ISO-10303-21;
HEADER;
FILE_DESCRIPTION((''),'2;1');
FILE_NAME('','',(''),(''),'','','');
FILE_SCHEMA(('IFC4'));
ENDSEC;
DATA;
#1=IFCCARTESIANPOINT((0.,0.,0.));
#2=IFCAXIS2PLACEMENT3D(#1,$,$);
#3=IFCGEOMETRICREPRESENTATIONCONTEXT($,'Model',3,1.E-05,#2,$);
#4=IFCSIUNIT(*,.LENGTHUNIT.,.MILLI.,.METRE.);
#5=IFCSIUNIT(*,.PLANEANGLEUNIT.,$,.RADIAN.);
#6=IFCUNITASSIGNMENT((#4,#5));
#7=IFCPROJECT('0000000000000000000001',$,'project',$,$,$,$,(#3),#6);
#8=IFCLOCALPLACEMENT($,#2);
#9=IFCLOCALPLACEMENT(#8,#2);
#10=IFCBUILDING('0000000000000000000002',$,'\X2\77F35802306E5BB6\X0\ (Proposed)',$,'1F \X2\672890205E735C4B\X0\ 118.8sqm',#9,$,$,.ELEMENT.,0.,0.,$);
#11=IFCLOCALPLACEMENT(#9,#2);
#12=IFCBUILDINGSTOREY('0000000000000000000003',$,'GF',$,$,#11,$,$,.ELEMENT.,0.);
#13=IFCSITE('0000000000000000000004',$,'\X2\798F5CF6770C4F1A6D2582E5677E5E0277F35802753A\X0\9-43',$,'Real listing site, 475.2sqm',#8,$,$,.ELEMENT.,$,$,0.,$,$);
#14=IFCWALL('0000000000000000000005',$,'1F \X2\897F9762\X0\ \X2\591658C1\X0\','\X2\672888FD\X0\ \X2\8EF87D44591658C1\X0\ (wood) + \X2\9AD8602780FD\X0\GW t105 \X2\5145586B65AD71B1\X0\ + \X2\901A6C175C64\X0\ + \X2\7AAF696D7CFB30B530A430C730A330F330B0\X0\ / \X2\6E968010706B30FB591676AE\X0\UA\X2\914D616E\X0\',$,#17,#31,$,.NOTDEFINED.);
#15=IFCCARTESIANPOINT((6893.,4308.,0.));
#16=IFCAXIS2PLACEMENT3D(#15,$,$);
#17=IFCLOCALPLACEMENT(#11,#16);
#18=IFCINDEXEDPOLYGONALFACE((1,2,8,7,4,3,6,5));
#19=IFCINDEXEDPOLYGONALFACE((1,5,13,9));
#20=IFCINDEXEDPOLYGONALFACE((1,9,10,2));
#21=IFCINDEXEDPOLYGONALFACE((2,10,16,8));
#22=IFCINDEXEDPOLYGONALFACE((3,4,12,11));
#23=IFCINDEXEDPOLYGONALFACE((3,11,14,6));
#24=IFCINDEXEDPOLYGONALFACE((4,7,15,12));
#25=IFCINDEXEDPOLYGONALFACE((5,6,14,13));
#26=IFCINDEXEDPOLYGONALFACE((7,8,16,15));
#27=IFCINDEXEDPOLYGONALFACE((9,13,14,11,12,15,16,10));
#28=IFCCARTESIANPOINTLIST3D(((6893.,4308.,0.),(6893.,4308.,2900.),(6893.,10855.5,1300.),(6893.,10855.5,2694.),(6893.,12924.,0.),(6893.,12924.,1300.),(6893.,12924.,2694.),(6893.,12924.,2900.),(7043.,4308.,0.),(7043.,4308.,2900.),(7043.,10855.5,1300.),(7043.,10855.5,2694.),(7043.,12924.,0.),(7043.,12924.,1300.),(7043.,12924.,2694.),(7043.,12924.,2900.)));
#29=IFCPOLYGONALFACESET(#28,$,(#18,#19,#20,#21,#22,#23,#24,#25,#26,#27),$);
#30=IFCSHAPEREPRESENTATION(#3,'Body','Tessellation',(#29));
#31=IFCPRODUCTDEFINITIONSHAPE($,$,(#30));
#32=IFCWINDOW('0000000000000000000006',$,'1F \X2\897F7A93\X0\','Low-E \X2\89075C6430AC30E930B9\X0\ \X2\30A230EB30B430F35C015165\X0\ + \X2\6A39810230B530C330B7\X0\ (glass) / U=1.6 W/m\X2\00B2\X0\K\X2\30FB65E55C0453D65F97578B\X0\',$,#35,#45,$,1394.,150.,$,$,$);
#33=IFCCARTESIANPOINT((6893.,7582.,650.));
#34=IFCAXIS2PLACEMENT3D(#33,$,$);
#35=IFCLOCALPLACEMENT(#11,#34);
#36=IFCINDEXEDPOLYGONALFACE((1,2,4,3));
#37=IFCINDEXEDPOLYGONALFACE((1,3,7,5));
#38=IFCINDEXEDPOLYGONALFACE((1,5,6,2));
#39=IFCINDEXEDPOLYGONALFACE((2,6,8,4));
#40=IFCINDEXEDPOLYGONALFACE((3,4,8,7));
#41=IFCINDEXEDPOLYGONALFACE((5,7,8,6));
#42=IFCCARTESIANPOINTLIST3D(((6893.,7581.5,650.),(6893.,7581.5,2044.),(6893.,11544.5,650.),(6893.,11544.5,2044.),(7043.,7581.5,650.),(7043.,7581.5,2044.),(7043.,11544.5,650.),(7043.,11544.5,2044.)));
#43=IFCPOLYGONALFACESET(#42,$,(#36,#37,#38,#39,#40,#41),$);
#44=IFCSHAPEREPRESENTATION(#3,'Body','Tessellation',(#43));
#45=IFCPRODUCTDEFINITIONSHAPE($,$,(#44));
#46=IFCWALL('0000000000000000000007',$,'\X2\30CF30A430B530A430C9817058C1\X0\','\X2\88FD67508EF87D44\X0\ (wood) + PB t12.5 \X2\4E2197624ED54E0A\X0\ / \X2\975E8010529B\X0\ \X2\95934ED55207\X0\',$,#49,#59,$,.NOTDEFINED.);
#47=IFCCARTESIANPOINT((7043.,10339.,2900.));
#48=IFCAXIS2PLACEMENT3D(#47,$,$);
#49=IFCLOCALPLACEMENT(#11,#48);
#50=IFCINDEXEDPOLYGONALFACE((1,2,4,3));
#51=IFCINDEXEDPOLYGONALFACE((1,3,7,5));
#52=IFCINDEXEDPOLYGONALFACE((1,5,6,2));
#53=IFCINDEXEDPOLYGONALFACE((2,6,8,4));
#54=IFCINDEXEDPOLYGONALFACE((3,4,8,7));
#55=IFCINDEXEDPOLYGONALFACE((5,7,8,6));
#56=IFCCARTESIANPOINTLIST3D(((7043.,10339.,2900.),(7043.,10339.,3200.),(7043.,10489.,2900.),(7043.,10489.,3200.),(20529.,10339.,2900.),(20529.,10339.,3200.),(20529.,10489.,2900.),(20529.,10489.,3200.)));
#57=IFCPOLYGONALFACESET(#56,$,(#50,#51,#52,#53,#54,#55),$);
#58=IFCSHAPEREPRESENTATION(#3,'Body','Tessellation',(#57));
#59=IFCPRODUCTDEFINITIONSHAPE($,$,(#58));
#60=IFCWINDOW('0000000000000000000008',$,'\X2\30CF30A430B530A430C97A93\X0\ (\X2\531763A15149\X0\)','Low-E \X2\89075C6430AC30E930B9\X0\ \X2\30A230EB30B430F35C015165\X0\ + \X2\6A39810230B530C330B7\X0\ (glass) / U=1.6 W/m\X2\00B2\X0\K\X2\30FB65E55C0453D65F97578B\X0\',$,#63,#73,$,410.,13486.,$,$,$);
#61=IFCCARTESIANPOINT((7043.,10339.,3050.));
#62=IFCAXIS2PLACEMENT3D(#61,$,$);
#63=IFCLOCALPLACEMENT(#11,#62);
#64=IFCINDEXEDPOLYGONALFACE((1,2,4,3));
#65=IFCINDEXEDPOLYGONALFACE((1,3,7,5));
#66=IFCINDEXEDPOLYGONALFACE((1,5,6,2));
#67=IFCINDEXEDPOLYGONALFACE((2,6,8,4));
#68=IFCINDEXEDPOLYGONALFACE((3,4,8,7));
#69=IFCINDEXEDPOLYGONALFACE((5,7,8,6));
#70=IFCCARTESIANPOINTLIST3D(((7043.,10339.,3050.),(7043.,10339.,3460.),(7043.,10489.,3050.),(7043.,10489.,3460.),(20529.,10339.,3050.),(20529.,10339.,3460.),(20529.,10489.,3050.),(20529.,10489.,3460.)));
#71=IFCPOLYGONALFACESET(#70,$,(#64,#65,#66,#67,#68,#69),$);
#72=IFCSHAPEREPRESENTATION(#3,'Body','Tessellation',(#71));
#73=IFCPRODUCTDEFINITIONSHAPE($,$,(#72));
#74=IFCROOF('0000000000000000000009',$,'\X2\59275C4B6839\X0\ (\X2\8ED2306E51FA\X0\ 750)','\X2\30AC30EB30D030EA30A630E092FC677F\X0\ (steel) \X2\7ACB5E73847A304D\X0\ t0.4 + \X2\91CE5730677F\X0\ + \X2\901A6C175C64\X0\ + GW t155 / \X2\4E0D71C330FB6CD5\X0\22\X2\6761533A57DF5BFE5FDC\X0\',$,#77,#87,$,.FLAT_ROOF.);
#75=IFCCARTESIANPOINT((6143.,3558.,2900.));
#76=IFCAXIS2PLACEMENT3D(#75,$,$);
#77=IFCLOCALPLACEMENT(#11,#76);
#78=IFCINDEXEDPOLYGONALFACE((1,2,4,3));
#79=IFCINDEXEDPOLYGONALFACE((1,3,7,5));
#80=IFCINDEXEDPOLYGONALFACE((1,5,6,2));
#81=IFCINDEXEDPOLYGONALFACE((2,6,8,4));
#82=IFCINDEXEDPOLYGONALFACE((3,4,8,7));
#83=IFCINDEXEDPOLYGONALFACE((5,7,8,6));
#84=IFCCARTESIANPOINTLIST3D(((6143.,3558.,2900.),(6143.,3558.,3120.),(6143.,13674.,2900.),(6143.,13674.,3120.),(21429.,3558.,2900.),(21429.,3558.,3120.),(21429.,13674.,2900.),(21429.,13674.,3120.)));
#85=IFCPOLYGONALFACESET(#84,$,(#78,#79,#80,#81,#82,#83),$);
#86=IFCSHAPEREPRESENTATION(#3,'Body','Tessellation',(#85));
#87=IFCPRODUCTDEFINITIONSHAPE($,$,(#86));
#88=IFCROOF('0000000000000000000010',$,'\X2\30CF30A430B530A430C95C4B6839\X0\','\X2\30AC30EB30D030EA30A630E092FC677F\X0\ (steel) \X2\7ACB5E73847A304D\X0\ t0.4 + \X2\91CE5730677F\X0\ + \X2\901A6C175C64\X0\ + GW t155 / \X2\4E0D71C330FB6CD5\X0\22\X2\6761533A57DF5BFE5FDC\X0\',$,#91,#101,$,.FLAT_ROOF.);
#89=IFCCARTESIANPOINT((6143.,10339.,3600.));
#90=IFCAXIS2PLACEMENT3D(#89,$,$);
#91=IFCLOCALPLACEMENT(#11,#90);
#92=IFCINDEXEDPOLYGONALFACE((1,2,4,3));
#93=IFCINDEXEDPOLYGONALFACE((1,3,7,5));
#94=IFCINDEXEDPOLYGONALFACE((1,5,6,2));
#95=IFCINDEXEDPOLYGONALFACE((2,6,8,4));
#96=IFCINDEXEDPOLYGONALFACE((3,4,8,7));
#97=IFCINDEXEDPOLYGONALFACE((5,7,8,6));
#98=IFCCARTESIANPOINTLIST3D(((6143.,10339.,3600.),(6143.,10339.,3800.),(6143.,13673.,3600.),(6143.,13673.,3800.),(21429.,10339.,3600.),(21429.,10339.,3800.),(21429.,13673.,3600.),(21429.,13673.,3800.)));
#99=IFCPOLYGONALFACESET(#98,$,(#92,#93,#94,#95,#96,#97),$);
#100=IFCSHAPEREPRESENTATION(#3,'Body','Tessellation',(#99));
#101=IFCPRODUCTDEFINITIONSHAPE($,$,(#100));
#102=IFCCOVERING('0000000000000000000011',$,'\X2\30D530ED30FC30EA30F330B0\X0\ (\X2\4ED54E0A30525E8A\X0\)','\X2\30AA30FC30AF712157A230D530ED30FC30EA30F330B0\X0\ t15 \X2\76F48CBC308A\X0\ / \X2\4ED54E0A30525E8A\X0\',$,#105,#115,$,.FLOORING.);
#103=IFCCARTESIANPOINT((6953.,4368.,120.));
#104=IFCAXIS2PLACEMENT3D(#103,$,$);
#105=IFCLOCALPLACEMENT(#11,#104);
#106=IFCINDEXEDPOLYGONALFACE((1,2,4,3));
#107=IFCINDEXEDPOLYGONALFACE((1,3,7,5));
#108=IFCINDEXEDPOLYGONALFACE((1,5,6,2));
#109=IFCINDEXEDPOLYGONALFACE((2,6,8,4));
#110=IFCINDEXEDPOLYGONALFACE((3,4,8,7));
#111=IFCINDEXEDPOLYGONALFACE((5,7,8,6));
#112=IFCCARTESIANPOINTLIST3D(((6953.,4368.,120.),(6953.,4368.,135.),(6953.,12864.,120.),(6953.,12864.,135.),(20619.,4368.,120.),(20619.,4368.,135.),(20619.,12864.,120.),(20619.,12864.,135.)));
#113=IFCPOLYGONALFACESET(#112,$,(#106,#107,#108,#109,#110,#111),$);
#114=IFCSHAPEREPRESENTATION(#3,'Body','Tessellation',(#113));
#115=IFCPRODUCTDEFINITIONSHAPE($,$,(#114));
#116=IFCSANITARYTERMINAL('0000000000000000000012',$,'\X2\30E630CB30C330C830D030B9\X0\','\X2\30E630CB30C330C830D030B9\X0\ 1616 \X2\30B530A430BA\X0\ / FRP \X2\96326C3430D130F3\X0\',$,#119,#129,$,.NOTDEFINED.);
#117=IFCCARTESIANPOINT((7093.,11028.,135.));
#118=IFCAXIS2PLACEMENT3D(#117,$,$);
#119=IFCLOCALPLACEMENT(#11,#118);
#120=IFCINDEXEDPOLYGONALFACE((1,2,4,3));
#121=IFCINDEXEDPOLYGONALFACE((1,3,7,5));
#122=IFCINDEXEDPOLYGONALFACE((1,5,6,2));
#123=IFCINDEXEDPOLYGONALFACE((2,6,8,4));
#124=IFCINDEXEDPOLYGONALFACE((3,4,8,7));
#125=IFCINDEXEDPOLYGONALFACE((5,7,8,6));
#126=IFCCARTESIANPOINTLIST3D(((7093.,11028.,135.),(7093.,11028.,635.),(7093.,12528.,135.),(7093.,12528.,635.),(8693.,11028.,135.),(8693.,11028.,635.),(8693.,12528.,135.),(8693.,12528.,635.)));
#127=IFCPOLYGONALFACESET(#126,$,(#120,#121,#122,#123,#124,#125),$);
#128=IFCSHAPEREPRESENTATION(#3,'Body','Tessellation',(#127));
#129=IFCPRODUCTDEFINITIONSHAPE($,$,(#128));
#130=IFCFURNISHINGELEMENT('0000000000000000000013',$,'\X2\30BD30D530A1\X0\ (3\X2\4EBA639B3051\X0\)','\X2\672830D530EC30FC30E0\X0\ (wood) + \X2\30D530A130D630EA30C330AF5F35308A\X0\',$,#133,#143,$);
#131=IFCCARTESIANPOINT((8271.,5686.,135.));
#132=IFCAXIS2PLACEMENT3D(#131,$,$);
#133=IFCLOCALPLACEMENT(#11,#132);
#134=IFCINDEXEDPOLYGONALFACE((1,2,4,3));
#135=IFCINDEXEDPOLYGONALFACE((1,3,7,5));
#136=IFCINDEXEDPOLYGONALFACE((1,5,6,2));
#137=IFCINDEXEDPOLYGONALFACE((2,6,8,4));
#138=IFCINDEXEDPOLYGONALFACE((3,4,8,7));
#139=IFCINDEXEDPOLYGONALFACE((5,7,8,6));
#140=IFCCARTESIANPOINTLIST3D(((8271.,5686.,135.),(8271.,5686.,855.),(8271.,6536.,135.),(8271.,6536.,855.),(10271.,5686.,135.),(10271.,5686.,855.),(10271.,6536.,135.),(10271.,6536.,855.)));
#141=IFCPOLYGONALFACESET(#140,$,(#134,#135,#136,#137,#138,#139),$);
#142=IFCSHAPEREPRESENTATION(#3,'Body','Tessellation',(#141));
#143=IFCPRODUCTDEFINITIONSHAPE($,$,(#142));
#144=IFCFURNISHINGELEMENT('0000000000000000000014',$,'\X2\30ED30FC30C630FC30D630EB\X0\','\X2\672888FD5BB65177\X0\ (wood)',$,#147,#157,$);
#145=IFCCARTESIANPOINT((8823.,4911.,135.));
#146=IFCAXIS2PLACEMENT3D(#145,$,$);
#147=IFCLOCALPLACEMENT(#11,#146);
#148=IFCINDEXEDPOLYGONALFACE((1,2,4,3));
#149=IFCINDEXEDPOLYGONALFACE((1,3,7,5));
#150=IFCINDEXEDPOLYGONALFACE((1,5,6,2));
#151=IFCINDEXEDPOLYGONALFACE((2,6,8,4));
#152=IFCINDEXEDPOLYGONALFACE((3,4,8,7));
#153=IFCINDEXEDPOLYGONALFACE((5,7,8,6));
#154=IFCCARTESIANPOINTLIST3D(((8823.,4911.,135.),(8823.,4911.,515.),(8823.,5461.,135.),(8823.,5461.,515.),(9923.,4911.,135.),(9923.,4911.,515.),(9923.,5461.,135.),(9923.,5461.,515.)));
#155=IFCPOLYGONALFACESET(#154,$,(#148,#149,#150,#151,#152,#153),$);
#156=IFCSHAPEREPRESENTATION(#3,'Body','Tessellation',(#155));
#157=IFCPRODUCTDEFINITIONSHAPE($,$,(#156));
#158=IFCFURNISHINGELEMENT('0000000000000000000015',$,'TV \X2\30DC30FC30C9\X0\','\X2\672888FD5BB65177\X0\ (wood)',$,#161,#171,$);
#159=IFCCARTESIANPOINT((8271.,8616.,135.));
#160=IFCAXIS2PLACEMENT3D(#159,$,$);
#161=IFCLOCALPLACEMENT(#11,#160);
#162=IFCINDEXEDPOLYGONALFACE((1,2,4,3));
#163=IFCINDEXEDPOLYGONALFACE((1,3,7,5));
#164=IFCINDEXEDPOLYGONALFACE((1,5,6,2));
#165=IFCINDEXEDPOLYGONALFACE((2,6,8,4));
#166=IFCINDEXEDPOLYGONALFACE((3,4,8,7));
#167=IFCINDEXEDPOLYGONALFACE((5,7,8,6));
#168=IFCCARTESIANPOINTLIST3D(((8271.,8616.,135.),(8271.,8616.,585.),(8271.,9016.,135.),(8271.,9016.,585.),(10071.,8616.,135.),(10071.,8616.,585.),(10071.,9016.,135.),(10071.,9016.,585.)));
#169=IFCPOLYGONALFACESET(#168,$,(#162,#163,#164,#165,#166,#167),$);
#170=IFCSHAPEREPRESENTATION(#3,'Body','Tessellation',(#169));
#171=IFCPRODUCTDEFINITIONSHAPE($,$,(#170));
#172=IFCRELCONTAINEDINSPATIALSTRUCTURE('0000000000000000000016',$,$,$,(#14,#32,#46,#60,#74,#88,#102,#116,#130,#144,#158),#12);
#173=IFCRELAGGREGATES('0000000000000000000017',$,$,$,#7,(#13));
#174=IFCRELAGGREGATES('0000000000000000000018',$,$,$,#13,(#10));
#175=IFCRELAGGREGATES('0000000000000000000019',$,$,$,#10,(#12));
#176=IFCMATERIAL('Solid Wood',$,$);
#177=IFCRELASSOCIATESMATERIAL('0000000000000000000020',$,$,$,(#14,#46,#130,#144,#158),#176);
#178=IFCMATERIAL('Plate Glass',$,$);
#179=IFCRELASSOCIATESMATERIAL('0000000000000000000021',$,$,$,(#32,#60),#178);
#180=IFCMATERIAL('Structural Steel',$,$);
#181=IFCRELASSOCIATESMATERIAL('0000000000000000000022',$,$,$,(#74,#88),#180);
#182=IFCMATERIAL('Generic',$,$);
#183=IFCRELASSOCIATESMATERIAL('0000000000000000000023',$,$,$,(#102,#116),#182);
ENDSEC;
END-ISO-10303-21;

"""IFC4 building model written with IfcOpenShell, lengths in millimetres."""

from ifc_helpers import new_model, si_unit, frame, frame_2d, origin, place, context, project, spatial, rectangle, extrude, material, element, fill, save


model = new_model("IFC4")

# Units and contexts
model_context = context("Model", 3, precision=1e-05, world=origin())
ifc_project = project(units=[si_unit("LENGTHUNIT", "METRE", prefix="MILLI"), si_unit("PLANEANGLEUNIT", "RADIAN")], contexts=[model_context])

# Site, building, storey
site_placement = place(None, origin())
site = spatial("IfcSite", under=ifc_project, at=site_placement, Name="福島県会津若松市石堂町9-43", ObjectType="Real listing site, 475.2sqm", CompositionType="ELEMENT", RefElevation=0.0)
building_placement = place(site_placement, origin())
building = spatial("IfcBuilding", under=site, at=building_placement, Name="石堂の家 (Proposed)", ObjectType="1F 木造平屋 118.8sqm", CompositionType="ELEMENT", ElevationOfRefHeight=0.0, ElevationOfTerrain=0.0)
storey_placement = place(building_placement, origin())
storey = spatial("IfcBuildingStorey", under=building, at=storey_placement, Name="GF", CompositionType="ELEMENT", Elevation=0.0)

# Shared definitions
ifc_material_1 = material(Name="Solid Wood")

# Shared definitions
ifc_material_2 = material(Name="Plate Glass")

# Wall, opening, window
wall_1_placement = place(storey_placement, frame((6893.0, 4308.0, 0.0)))
wall_1 = element("IfcWall", 1, at=wall_1_placement, inside=storey, material=ifc_material_1, Name="1F 西面 外壁", Description="木製 軸組外壁 (wood) + 高性能GW t105 充填断熱 + 通気層 + 窯業系サイディング / 準耐火・外皮UA配慮", PredefinedType="NOTDEFINED", context=model_context, shape_type="SweptSolid", body=[
    extrude(rectangle(XDim=150.0, YDim=8616.0, at=frame_2d((75.0, 4308.0))), frame((6893.0, 4308.0, 0.0)), (0.0, 0.0, 1.0), 2900.0),
])
opening_1_placement = place(storey_placement, frame((6893.0, 7582.0, 650.0)))
opening_1 = element("IfcOpeningElement", 2, at=opening_1_placement, cuts=wall_1, PredefinedType="NOTDEFINED", context=model_context, shape_type="SweptSolid", body=[
    extrude(rectangle(XDim=150.0, YDim=3963.0, at=frame_2d((75.0, 1981.0))), frame((6893.0, 7582.0, 650.0)), (0.0, 0.0, 1.0), 1394.0),
])
window_1_placement = place(storey_placement, frame((6893.0, 7582.0, 650.0)))
window_1 = element("IfcWindow", 3, at=window_1_placement, inside=storey, material=ifc_material_2, Name="1F 西窓", Description="Low-E 複層ガラス アルゴン封入 + 樹脂サッシ (glass) / U=1.6 W/m²K・日射取得型", OverallHeight=1394.0, OverallWidth=150.0, context=model_context, shape_type="SweptSolid", body=[
    extrude(rectangle(XDim=150.0, YDim=3963.0, at=frame_2d((75.0, 1981.0))), frame((6893.0, 7582.0, 650.0)), (0.0, 0.0, 1.0), 1394.0),
])
fill(opening_1, window_1)

# Wall, opening, window
wall_2_placement = place(storey_placement, frame((7043.0, 10339.0, 2900.0)))
wall_2 = element("IfcWall", 4, at=wall_2_placement, inside=storey, material=ifc_material_1, Name="ハイサイド腰壁", Description="製材軸組 (wood) + PB t12.5 両面仕上 / 非耐力 間仕切", PredefinedType="NOTDEFINED", context=model_context, shape_type="SweptSolid", body=[
    extrude(rectangle(XDim=13486.0, YDim=150.0, at=frame_2d((6743.0, 75.0))), frame((7043.0, 10339.0, 2900.0)), (0.0, 0.0, 1.0), 700.0),
])
opening_2_placement = place(storey_placement, frame((7043.0, 10339.0, 3050.0)))
opening_2 = element("IfcOpeningElement", 5, at=opening_2_placement, cuts=wall_2, PredefinedType="NOTDEFINED", context=model_context, shape_type="SweptSolid", body=[
    extrude(rectangle(XDim=13486.0, YDim=150.0, at=frame_2d((6743.0, 75.0))), frame((7043.0, 10339.0, 3050.0)), (0.0, 0.0, 1.0), 410.0),
])
window_2_placement = place(storey_placement, frame((7043.0, 10339.0, 3050.0)))
window_2 = element("IfcWindow", 6, at=window_2_placement, inside=storey, material=ifc_material_2, Name="ハイサイド窓 (北採光)", Description="Low-E 複層ガラス アルゴン封入 + 樹脂サッシ (glass) / U=1.6 W/m²K・日射取得型", OverallHeight=410.0, OverallWidth=13486.0, context=model_context, shape_type="SweptSolid", body=[
    extrude(rectangle(XDim=13486.0, YDim=150.0, at=frame_2d((6743.0, 75.0))), frame((7043.0, 10339.0, 3050.0)), (0.0, 0.0, 1.0), 410.0),
])
fill(opening_2, window_2)

# Roofs
ifc_material_3 = material(Name="Structural Steel")
roof_1_placement = place(storey_placement, frame((6143.0, 3558.0, 2900.0)))
element("IfcRoof", 7, at=roof_1_placement, inside=storey, material=ifc_material_3, Name="大屋根 (軒の出 750)", Description="ガルバリウム鋼板 (steel) 立平葺き t0.4 + 野地板 + 通気層 + GW t155 / 不燃・法22条区域対応", PredefinedType="FLAT_ROOF", context=model_context, shape_type="SweptSolid", body=[
    extrude(rectangle(XDim=15286.0, YDim=10116.0, at=frame_2d((7643.0, 5058.0))), frame((6143.0, 3558.0, 2900.0)), (0.0, 0.0, 1.0), 220.0),
])
roof_2_placement = place(storey_placement, frame((6143.0, 10339.0, 3600.0)))
element("IfcRoof", 8, at=roof_2_placement, inside=storey, material=ifc_material_3, Name="ハイサイド屋根", Description="ガルバリウム鋼板 (steel) 立平葺き t0.4 + 野地板 + 通気層 + GW t155 / 不燃・法22条区域対応", PredefinedType="FLAT_ROOF", context=model_context, shape_type="SweptSolid", body=[
    extrude(rectangle(XDim=15286.0, YDim=3334.0, at=frame_2d((7643.0, 1667.0))), frame((6143.0, 10339.0, 3600.0)), (0.0, 0.0, 1.0), 200.0),
])

# Covering
ifc_material_4 = material(Name="Generic")
covering_placement = place(storey_placement, frame((6953.0, 4368.0, 120.0)))
element("IfcCovering", 9, at=covering_placement, inside=storey, material=ifc_material_4, Name="フローリング (仕上げ床)", Description="オーク無垢フローリング t15 直貼り / 仕上げ床", PredefinedType="FLOORING", context=model_context, shape_type="SweptSolid", body=[
    extrude(rectangle(XDim=13666.0, YDim=8496.0, at=frame_2d((6833.0, 4248.0))), frame((6953.0, 4368.0, 120.0)), (0.0, 0.0, 1.0), 15.0),
])

# Sanitary terminal
sanitary_terminal_placement = place(storey_placement, frame((7093.0, 11028.0, 135.0)))
element("IfcSanitaryTerminal", 10, at=sanitary_terminal_placement, inside=storey, material=ifc_material_4, Name="ユニットバス", Description="ユニットバス 1616 サイズ / FRP 防水パン", PredefinedType="NOTDEFINED", context=model_context, shape_type="SweptSolid", body=[
    extrude(rectangle(XDim=1600.0, YDim=1500.0, at=frame_2d((800.0, 750.0))), frame((7093.0, 11028.0, 135.0)), (0.0, 0.0, 1.0), 500.0),
])

# Furnishing elements
furnishing_1_placement = place(storey_placement, frame((8271.0, 5686.0, 135.0)))
element("IfcFurnishingElement", 11, at=furnishing_1_placement, inside=storey, material=ifc_material_1, Name="ソファ (3人掛け)", Description="木フレーム (wood) + ファブリック張り", context=model_context, shape_type="SweptSolid", body=[
    extrude(rectangle(XDim=2000.0, YDim=850.0, at=frame_2d((1000.0, 425.0))), frame((8271.0, 5686.0, 135.0)), (0.0, 0.0, 1.0), 720.0),
])
furnishing_2_placement = place(storey_placement, frame((8823.0, 4911.0, 135.0)))
element("IfcFurnishingElement", 12, at=furnishing_2_placement, inside=storey, material=ifc_material_1, Name="ローテーブル", Description="木製家具 (wood)", context=model_context, shape_type="SweptSolid", body=[
    extrude(rectangle(XDim=1100.0, YDim=550.0, at=frame_2d((550.0, 275.0))), frame((8823.0, 4911.0, 135.0)), (0.0, 0.0, 1.0), 380.0),
])
furnishing_3_placement = place(storey_placement, frame((8271.0, 8616.0, 135.0)))
element("IfcFurnishingElement", 13, at=furnishing_3_placement, inside=storey, material=ifc_material_1, Name="TV ボード", Description="木製家具 (wood)", context=model_context, shape_type="SweptSolid", body=[
    extrude(rectangle(XDim=1800.0, YDim=400.0, at=frame_2d((900.0, 200.0))), frame((8271.0, 8616.0, 135.0)), (0.0, 0.0, 1.0), 450.0),
])

save(model, "model.ifc")
